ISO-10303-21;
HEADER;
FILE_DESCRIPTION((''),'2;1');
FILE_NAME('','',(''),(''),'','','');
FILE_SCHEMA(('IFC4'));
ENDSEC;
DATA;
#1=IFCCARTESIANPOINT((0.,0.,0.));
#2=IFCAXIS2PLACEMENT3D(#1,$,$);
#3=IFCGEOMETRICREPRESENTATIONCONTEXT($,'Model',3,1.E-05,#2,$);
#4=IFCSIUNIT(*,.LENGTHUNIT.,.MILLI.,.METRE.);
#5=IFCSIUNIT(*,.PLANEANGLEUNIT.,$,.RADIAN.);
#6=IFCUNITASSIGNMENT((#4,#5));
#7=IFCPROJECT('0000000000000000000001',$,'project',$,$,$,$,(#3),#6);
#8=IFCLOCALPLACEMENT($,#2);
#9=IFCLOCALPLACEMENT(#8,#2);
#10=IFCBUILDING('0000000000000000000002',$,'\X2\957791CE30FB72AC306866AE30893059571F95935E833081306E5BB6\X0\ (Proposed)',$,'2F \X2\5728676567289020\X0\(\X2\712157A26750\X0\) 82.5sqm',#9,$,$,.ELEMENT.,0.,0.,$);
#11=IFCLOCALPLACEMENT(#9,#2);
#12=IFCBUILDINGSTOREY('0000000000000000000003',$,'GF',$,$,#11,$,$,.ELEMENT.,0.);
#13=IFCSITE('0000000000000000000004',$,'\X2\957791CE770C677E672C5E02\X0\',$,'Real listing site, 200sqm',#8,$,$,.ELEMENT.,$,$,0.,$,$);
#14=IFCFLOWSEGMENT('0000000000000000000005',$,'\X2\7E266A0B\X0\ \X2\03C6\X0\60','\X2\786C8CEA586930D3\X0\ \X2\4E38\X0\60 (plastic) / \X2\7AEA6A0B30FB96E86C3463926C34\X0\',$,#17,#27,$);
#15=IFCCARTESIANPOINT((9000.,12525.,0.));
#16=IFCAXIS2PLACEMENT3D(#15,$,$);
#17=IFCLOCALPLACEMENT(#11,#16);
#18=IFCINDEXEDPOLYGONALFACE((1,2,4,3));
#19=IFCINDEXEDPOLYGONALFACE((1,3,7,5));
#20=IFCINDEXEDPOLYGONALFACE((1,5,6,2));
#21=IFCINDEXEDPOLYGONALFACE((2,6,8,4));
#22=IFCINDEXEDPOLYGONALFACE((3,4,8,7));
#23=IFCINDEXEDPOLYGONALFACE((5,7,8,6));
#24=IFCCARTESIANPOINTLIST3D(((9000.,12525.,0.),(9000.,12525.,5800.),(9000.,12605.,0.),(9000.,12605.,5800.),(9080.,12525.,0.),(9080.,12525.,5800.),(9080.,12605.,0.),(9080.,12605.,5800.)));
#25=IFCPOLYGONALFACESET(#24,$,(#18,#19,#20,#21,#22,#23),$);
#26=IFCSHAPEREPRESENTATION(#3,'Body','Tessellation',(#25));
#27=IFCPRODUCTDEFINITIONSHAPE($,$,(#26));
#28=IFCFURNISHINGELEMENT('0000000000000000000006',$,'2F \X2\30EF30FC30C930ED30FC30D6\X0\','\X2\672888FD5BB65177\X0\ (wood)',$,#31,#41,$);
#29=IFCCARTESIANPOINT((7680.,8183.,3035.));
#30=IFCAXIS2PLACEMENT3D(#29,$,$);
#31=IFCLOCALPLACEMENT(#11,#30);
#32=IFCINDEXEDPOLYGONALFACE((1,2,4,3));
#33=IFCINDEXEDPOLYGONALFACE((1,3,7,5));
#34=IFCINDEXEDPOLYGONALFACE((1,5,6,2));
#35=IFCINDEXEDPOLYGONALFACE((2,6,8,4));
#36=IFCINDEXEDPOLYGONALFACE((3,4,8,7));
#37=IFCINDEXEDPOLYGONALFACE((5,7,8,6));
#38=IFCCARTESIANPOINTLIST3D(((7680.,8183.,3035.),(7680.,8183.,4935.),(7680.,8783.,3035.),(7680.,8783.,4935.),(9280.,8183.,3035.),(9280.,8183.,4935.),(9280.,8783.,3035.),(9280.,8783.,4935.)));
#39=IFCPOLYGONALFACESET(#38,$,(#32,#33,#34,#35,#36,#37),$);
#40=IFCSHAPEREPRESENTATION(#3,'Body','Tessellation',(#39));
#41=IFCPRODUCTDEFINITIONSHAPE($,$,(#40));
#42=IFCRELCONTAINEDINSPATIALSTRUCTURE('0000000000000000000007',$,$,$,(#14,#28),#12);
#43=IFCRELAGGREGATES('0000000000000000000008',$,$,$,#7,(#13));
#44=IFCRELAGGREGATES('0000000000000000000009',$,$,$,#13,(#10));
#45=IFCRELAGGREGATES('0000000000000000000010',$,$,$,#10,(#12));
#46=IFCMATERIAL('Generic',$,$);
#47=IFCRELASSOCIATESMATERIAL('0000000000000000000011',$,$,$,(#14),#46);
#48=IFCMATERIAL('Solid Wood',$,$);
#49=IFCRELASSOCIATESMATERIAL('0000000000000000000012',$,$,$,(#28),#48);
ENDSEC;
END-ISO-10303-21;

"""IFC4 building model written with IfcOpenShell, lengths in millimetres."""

from ifc_helpers import new_model, si_unit, frame, frame_2d, origin, place, context, project, spatial, rectangle, extrude, material, element, save


model = new_model("IFC4")

# Units and contexts
model_context = context("Model", 3, precision=1e-05, world=origin())
ifc_project = project(units=[si_unit("LENGTHUNIT", "METRE", prefix="MILLI"), si_unit("PLANEANGLEUNIT", "RADIAN")], contexts=[model_context])

# Site, building, storey
site_placement = place(None, origin())
site = spatial("IfcSite", under=ifc_project, at=site_placement, Name="長野県松本市", ObjectType="Real listing site, 200sqm", CompositionType="ELEMENT", RefElevation=0.0)
building_placement = place(site_placement, origin())
building = spatial("IfcBuilding", under=site, at=building_placement, Name="長野・犬と暮らす土間広めの家 (Proposed)", ObjectType="2F 在来木造(無垢材) 82.5sqm", CompositionType="ELEMENT", ElevationOfRefHeight=0.0, ElevationOfTerrain=0.0)
storey_placement = place(building_placement, origin())
storey = spatial("IfcBuildingStorey", under=building, at=storey_placement, Name="GF", CompositionType="ELEMENT", Elevation=0.0)

# Shared definitions
ifc_material_1 = material(Name="Solid Wood")

# Shared definitions
ifc_material_2 = material(Name="Generic")

# Flow segment
flow_segment_placement = place(storey_placement, frame((9000.0, 12525.0, 0.0)))
element("IfcFlowSegment", 1, at=flow_segment_placement, inside=storey, material=ifc_material_2, Name="縦樋 φ60", Description="硬質塩ビ 丸60 (plastic) / 竪樋・雨水排水", context=model_context, shape_type="SweptSolid", body=[
    extrude(rectangle(XDim=80.0, YDim=80.0, at=frame_2d((40.0, 40.0))), frame((9000.0, 12525.0, 0.0)), (0.0, 0.0, 1.0), 5800.0),
])

# Furnishing element
furnishing_placement = place(storey_placement, frame((7680.0, 8183.0, 3035.0)))
element("IfcFurnishingElement", 2, at=furnishing_placement, inside=storey, material=ifc_material_1, Name="2F ワードローブ", Description="木製家具 (wood)", context=model_context, shape_type="SweptSolid", body=[
    extrude(rectangle(XDim=1600.0, YDim=600.0, at=frame_2d((800.0, 300.0))), frame((7680.0, 8183.0, 3035.0)), (0.0, 0.0, 1.0), 1900.0),
])

save(model, "model.ifc")
